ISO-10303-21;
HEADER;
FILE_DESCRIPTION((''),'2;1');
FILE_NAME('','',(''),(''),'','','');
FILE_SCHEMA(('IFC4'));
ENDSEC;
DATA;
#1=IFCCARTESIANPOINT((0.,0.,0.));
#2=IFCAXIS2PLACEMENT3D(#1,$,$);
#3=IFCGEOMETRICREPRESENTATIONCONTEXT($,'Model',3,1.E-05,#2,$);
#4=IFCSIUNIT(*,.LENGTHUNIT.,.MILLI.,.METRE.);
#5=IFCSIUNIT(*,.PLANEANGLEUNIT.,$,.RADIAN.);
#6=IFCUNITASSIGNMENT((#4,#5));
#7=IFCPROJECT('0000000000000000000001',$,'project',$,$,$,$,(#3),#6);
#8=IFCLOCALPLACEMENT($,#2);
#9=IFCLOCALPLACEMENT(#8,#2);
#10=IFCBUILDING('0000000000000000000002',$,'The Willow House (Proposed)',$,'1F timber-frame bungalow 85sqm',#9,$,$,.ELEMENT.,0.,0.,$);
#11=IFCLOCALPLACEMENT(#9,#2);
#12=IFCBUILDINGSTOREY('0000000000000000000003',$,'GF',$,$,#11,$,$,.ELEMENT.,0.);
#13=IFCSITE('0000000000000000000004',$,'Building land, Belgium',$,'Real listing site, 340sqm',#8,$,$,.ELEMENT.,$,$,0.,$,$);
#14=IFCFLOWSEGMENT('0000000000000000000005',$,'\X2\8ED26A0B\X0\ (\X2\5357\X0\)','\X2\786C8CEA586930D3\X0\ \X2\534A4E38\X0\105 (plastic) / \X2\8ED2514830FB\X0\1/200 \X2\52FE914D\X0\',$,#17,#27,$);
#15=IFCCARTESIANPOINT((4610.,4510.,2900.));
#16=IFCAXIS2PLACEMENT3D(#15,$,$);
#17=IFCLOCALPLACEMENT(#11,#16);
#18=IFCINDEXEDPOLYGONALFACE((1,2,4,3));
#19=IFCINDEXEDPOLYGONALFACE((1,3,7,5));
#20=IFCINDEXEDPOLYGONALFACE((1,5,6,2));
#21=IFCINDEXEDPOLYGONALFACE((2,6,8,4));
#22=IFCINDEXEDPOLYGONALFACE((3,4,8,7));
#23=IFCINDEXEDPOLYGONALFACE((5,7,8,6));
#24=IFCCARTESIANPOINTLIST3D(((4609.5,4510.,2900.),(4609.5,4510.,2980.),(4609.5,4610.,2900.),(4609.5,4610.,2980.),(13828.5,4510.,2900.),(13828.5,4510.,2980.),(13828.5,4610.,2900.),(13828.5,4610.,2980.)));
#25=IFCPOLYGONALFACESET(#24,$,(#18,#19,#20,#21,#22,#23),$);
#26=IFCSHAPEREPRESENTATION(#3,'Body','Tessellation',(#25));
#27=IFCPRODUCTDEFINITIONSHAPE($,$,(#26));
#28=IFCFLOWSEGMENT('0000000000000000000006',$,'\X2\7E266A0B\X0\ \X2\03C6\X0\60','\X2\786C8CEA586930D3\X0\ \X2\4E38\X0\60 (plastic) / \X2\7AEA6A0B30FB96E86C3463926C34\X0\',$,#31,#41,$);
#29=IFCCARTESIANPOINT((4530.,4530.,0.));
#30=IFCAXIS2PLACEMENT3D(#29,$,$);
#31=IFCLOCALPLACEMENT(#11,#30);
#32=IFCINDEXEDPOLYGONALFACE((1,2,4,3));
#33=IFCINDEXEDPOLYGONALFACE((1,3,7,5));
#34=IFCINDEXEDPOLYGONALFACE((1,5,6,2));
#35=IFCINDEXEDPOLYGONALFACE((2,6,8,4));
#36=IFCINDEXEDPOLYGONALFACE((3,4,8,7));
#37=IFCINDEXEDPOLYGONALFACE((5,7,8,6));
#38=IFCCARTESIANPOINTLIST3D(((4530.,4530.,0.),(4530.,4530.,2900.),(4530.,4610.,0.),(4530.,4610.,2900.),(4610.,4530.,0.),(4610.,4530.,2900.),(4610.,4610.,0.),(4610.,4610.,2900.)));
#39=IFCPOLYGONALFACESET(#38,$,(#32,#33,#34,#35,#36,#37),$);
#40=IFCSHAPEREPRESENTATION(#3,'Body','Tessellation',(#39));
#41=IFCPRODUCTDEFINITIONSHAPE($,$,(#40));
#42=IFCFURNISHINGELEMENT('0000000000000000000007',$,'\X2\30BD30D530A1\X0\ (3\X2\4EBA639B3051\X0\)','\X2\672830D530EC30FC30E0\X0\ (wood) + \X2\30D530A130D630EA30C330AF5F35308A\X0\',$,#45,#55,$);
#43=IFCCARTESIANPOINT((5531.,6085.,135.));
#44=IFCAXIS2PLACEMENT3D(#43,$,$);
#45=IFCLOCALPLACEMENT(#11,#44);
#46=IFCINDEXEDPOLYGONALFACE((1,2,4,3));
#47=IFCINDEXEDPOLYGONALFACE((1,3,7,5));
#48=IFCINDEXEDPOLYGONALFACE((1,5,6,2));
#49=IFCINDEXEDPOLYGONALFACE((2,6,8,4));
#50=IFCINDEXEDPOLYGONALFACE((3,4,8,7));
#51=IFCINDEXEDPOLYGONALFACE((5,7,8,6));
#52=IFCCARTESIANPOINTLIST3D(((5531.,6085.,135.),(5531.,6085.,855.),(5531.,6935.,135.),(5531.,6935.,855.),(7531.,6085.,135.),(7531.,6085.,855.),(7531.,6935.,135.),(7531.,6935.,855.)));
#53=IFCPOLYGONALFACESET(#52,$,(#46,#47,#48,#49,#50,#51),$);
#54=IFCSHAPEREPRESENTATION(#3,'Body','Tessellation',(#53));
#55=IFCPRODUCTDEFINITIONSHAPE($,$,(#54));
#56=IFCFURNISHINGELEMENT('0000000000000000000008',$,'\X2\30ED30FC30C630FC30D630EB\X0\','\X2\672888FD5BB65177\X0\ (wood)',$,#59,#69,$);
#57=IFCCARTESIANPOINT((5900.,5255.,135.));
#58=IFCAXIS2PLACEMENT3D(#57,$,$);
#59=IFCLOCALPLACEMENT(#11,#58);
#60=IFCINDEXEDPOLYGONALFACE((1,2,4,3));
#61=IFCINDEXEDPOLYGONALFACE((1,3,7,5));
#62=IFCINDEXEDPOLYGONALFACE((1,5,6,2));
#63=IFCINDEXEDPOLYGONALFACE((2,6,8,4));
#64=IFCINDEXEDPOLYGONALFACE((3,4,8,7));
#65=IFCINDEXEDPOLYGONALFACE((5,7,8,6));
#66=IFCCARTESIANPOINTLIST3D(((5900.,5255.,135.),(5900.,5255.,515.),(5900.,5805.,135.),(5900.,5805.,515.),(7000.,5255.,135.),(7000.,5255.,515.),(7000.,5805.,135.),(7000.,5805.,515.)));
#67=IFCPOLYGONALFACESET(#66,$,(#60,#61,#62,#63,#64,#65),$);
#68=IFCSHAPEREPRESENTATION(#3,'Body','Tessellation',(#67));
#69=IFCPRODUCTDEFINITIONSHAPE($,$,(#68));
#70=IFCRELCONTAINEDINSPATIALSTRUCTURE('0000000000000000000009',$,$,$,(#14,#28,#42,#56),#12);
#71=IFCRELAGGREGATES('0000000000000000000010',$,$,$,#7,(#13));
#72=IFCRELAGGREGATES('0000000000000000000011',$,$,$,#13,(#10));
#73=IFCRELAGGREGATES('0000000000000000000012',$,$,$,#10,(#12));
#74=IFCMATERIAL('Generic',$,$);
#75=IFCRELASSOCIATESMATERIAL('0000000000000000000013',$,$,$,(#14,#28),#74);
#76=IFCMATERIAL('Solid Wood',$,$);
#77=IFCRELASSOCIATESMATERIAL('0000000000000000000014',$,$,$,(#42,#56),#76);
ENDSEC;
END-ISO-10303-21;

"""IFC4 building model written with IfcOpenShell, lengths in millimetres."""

from ifc_helpers import new_model, si_unit, frame, frame_2d, origin, place, context, project, spatial, rectangle, extrude, material, element, save


model = new_model("IFC4")

# Units and contexts
model_context = context("Model", 3, precision=1e-05, world=origin())
ifc_project = project(units=[si_unit("LENGTHUNIT", "METRE", prefix="MILLI"), si_unit("PLANEANGLEUNIT", "RADIAN")], contexts=[model_context])

# Site, building, storey
site_placement = place(None, origin())
site = spatial("IfcSite", under=ifc_project, at=site_placement, Name="Building land, Belgium", ObjectType="Real listing site, 340sqm", CompositionType="ELEMENT", RefElevation=0.0)
building_placement = place(site_placement, origin())
building = spatial("IfcBuilding", under=site, at=building_placement, Name="The Willow House (Proposed)", ObjectType="1F timber-frame bungalow 85sqm", CompositionType="ELEMENT", ElevationOfRefHeight=0.0, ElevationOfTerrain=0.0)
storey_placement = place(building_placement, origin())
storey = spatial("IfcBuildingStorey", under=building, at=storey_placement, Name="GF", CompositionType="ELEMENT", Elevation=0.0)

# Shared definitions
ifc_material_1 = material(Name="Solid Wood")

# Shared definitions
ifc_material_2 = material(Name="Generic")

# Flow segments
flow_segment_1_placement = place(storey_placement, frame((4610.0, 4510.0, 2900.0)))
element("IfcFlowSegment", 1, at=flow_segment_1_placement, inside=storey, material=ifc_material_2, Name="軒樋 (南)", Description="硬質塩ビ 半丸105 (plastic) / 軒先・1/200 勾配", context=model_context, shape_type="SweptSolid", body=[
    extrude(rectangle(XDim=9219.0, YDim=100.0, at=frame_2d((4609.0, 50.0))), frame((4610.0, 4510.0, 2900.0)), (0.0, 0.0, 1.0), 80.0),
])
flow_segment_2_placement = place(storey_placement, frame((4530.0, 4530.0, 0.0)))
element("IfcFlowSegment", 2, at=flow_segment_2_placement, inside=storey, material=ifc_material_2, Name="縦樋 φ60", Description="硬質塩ビ 丸60 (plastic) / 竪樋・雨水排水", context=model_context, shape_type="SweptSolid", body=[
    extrude(rectangle(XDim=80.0, YDim=80.0, at=frame_2d((40.0, 40.0))), frame((4530.0, 4530.0, 0.0)), (0.0, 0.0, 1.0), 2900.0),
])

# Furnishing elements
furnishing_1_placement = place(storey_placement, frame((5531.0, 6085.0, 135.0)))
element("IfcFurnishingElement", 3, at=furnishing_1_placement, inside=storey, material=ifc_material_1, Name="ソファ (3人掛け)", Description="木フレーム (wood) + ファブリック張り", context=model_context, shape_type="SweptSolid", body=[
    extrude(rectangle(XDim=2000.0, YDim=850.0, at=frame_2d((1000.0, 425.0))), frame((5531.0, 6085.0, 135.0)), (0.0, 0.0, 1.0), 720.0),
])
furnishing_2_placement = place(storey_placement, frame((5900.0, 5255.0, 135.0)))
element("IfcFurnishingElement", 4, at=furnishing_2_placement, inside=storey, material=ifc_material_1, Name="ローテーブル", Description="木製家具 (wood)", context=model_context, shape_type="SweptSolid", body=[
    extrude(rectangle(XDim=1100.0, YDim=550.0, at=frame_2d((550.0, 275.0))), frame((5900.0, 5255.0, 135.0)), (0.0, 0.0, 1.0), 380.0),
])

save(model, "model.ifc")
